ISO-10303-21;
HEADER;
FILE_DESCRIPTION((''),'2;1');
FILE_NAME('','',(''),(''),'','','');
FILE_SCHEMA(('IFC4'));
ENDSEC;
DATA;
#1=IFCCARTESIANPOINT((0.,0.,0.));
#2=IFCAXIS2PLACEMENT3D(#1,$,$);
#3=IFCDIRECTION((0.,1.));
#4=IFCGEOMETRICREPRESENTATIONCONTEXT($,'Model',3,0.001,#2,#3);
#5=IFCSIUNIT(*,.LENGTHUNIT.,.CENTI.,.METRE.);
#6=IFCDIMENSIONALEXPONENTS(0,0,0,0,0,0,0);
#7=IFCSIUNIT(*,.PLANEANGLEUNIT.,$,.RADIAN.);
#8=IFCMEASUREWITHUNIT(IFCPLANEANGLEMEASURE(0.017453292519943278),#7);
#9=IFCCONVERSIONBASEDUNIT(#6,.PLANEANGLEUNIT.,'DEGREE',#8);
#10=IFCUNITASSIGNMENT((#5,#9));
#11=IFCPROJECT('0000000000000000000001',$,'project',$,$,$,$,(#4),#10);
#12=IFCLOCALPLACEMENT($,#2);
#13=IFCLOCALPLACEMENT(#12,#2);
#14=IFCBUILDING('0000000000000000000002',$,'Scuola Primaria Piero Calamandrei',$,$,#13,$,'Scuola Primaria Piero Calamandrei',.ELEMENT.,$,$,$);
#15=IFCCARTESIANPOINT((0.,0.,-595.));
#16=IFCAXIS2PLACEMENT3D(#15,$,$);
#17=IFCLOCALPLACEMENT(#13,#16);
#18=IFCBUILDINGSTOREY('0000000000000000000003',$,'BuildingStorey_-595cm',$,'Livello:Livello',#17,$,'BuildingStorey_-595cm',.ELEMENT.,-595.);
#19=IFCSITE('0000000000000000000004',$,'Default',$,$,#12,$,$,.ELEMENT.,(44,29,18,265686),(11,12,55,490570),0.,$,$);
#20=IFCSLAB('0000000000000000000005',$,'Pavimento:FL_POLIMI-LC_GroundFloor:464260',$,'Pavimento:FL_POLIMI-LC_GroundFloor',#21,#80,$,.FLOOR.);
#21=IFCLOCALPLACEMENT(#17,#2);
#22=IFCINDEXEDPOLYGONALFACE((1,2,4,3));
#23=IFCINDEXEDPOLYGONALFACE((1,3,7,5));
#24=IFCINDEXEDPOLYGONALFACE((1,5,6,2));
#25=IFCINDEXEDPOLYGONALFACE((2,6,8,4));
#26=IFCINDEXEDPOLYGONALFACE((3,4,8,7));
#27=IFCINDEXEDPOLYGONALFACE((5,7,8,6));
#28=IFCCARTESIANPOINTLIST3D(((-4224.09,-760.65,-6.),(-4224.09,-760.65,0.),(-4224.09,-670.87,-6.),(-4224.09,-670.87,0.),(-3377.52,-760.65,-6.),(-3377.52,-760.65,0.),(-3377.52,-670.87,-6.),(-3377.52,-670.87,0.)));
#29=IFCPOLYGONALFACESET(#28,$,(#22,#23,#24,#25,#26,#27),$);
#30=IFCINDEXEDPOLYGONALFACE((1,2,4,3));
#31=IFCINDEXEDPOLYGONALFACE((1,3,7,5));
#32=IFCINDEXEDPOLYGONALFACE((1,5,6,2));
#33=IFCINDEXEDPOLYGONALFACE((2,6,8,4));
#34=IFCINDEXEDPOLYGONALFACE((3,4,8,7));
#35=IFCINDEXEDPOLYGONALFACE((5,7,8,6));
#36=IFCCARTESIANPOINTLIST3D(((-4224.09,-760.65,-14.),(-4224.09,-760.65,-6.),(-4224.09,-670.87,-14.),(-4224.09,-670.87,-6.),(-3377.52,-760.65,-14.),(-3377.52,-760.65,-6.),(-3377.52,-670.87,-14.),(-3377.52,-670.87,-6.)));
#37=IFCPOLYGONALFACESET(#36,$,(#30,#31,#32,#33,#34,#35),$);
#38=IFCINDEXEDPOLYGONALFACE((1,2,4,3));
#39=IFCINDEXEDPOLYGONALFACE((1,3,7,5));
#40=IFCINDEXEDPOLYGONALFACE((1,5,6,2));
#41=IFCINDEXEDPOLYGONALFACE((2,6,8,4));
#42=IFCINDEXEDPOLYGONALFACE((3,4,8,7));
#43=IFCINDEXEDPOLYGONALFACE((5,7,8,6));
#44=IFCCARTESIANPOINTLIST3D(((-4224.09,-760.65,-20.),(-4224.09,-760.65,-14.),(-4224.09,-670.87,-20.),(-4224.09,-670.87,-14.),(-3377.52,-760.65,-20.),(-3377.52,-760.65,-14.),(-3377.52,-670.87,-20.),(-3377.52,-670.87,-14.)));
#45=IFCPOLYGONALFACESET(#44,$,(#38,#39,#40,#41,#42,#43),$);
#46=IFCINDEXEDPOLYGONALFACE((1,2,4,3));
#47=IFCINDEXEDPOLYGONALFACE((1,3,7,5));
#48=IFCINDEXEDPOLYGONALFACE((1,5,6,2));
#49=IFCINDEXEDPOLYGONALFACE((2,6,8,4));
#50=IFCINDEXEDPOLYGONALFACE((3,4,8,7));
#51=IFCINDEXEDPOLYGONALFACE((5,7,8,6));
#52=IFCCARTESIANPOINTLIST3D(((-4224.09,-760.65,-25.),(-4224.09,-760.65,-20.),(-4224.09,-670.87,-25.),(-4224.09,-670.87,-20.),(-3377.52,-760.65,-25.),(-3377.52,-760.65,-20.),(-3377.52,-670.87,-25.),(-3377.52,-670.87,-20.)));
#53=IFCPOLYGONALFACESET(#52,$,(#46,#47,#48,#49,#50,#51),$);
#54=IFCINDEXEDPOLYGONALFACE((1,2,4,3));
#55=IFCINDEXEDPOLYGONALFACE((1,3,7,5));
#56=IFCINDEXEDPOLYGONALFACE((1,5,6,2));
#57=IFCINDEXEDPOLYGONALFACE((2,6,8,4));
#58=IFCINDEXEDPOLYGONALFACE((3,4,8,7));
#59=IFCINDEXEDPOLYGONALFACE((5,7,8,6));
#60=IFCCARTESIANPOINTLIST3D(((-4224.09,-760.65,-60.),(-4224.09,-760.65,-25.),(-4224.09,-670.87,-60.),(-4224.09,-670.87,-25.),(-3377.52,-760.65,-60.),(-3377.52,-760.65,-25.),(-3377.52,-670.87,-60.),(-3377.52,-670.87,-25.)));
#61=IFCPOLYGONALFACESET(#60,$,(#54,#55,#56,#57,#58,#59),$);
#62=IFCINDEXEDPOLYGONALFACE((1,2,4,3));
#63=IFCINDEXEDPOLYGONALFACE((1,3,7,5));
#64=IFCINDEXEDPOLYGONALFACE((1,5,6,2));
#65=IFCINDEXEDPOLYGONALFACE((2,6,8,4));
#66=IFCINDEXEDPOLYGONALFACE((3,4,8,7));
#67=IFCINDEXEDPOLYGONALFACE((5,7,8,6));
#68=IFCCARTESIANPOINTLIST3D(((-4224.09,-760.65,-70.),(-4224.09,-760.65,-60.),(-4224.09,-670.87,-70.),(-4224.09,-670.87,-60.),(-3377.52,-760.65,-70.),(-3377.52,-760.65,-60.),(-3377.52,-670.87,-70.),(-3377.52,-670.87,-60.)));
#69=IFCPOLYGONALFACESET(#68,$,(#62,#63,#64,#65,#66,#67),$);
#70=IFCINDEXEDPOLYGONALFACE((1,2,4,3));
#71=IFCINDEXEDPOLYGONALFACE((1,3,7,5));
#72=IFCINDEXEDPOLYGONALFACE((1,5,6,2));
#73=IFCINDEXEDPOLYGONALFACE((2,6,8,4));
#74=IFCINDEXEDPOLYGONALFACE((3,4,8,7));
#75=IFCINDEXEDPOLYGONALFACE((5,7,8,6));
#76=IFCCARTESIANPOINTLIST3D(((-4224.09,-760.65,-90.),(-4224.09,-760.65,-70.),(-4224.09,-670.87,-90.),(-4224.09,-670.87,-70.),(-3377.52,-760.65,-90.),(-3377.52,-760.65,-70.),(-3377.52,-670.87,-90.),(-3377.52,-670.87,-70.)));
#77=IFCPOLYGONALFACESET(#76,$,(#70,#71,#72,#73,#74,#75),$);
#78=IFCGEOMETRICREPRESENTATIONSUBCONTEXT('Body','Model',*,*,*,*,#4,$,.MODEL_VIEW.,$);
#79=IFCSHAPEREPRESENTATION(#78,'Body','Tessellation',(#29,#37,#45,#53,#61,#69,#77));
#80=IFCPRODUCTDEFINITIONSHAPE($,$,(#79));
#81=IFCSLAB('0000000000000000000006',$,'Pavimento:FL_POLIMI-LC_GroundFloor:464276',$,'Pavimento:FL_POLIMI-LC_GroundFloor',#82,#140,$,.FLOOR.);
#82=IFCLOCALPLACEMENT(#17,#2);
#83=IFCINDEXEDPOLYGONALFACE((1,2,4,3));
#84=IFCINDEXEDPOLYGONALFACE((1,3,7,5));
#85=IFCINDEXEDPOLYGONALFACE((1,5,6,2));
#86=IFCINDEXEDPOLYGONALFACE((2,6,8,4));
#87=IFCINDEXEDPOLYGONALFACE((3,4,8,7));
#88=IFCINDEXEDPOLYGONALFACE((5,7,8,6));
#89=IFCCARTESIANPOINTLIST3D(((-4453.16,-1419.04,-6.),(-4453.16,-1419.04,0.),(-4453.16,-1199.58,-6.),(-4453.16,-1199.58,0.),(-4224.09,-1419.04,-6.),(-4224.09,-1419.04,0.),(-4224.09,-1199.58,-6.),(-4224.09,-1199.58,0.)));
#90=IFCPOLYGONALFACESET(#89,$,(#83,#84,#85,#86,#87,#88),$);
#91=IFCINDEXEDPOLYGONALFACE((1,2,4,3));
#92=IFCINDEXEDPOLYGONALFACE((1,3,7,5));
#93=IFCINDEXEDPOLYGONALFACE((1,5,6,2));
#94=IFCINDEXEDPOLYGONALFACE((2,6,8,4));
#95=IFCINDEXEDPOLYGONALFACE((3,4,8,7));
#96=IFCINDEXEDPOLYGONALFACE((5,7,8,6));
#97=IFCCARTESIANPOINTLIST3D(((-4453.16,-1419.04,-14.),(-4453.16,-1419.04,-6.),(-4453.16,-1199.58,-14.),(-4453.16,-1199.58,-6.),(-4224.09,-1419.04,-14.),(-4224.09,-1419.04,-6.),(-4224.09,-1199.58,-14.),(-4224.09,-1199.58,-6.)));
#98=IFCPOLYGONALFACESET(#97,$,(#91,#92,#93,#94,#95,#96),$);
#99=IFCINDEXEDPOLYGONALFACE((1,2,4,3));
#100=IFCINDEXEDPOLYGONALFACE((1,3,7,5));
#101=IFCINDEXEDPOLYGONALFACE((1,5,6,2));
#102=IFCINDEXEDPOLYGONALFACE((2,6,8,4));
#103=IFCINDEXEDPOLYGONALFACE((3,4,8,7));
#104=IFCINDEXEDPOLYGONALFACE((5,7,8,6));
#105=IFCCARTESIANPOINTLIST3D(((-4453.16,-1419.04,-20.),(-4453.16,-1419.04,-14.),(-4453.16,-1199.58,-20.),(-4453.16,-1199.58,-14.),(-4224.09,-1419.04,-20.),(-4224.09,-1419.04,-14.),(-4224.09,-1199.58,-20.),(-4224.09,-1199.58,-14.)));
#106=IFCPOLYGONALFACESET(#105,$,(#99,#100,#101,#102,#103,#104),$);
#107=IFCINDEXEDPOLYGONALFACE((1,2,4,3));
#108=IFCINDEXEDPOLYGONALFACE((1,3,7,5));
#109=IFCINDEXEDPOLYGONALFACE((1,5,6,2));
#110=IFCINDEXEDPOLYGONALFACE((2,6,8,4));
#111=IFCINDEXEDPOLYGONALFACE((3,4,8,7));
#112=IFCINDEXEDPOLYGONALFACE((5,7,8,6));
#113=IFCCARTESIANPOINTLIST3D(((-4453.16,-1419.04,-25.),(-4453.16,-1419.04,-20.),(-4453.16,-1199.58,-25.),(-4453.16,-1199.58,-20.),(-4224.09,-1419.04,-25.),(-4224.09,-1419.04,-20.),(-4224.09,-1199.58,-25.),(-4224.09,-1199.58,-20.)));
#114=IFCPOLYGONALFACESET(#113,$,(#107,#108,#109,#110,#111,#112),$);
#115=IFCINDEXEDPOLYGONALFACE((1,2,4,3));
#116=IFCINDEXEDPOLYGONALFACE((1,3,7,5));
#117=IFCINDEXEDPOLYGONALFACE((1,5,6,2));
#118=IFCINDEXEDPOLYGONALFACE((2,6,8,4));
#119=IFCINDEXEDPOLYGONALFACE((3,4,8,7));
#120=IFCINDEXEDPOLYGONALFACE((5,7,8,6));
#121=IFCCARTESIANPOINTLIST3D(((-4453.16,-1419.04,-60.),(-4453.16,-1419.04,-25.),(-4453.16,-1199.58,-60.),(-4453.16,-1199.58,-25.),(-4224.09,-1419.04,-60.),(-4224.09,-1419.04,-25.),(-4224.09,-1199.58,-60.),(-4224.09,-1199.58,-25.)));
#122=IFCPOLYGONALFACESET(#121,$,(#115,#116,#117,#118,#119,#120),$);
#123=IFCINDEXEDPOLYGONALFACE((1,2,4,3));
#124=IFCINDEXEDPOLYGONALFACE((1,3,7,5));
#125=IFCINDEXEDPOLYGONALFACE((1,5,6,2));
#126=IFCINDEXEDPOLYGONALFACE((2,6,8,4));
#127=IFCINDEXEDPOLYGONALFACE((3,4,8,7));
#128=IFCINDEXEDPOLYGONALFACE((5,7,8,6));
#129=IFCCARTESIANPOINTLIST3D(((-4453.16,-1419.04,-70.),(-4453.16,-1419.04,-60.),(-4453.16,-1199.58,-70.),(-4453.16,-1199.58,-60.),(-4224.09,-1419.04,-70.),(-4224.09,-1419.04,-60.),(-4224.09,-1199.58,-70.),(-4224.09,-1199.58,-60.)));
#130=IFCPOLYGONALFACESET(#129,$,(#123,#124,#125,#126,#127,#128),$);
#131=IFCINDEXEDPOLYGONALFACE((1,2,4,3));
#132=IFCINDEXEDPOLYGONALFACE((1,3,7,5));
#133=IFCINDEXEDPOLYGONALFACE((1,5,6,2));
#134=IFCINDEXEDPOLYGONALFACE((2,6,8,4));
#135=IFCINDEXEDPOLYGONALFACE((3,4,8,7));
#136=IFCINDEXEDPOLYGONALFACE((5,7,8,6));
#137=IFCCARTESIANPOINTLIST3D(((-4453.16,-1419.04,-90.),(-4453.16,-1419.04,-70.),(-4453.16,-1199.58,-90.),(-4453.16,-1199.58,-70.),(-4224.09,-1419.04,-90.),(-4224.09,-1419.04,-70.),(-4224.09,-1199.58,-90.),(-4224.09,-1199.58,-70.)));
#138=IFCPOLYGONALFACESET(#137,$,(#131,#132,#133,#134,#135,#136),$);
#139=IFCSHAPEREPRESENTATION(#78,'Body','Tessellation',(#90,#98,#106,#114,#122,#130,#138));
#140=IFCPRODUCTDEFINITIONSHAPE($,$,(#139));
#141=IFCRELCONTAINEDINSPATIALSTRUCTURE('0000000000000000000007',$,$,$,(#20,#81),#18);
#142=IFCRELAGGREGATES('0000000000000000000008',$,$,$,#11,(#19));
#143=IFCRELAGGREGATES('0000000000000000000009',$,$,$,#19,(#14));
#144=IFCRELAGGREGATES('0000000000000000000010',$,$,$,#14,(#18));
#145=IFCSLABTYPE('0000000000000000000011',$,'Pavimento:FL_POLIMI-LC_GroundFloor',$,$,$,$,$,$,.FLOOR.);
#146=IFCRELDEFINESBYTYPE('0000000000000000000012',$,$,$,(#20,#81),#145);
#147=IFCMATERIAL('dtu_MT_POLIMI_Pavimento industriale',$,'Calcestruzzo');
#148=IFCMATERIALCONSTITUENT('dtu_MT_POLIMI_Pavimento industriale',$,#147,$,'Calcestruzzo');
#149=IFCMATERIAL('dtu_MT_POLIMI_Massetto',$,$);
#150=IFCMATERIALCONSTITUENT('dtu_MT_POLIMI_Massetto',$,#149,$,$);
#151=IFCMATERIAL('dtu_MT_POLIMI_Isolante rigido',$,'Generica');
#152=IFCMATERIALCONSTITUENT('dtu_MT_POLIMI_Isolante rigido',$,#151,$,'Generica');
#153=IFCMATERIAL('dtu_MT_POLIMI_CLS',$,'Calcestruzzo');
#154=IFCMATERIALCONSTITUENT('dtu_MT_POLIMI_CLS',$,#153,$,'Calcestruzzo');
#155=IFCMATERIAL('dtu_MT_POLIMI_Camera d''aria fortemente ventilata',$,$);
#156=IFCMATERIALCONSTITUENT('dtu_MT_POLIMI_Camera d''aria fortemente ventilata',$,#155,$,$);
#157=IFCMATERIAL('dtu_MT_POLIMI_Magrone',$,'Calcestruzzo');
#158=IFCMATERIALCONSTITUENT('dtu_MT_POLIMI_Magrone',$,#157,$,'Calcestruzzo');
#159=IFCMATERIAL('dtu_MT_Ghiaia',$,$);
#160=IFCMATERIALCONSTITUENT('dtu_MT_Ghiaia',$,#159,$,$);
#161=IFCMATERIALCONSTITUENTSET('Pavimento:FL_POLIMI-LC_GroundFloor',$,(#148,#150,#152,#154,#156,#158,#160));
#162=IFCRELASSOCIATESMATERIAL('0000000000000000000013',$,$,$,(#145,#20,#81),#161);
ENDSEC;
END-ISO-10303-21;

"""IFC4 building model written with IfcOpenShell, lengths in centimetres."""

from ifc_helpers import new_model, entity, si_unit, converted_unit, direction, frame, origin, place, context, subcontext, project, spatial, indexed_curve, outline, extrude, material, constituent, constituent_set, type_object, element, save


model = new_model("IFC4")

# Units and contexts
model_context = context("Model", 3, precision=0.001, world=origin(), true_north=direction((0.0, 1.0)))
body_context = subcontext(model_context, "Body", "Model", "MODEL_VIEW")
ifc_project = project(units=[si_unit("LENGTHUNIT", "METRE", prefix="CENTI"), converted_unit("PLANEANGLEUNIT", "DEGREE", entity("IfcPlaneAngleMeasure", 0.017453292519943278), si_unit("PLANEANGLEUNIT", "RADIAN"), dimensions=[0, 0, 0, 0, 0, 0, 0])], contexts=[model_context])

# Site, building, storey
site_placement = place(None, origin())
site = spatial("IfcSite", under=ifc_project, at=site_placement, Name="Default", CompositionType="ELEMENT", RefLatitude=(44, 29, 18, 265686), RefLongitude=(11, 12, 55, 490570), RefElevation=0.0)
building_placement = place(site_placement, origin())
building = spatial("IfcBuilding", under=site, at=building_placement, Name="Scuola Primaria Piero Calamandrei", LongName="Scuola Primaria Piero Calamandrei", CompositionType="ELEMENT")
storey_placement = place(building_placement, frame((0.0, 0.0, -595.0)))
storey = spatial("IfcBuildingStorey", under=building, at=storey_placement, Name="BuildingStorey_-595cm", ObjectType="Livello:Livello", LongName="BuildingStorey_-595cm", CompositionType="ELEMENT", Elevation=-595.0)

# Slabs
ifc_material_1 = material(Name="dtu_MT_POLIMI_Pavimento industriale", Category="Calcestruzzo")
ifc_constituent_1 = constituent(ifc_material_1, Name="dtu_MT_POLIMI_Pavimento industriale", Category="Calcestruzzo")
ifc_material_2 = material(Name="dtu_MT_POLIMI_Massetto")
ifc_constituent_2 = constituent(ifc_material_2, Name="dtu_MT_POLIMI_Massetto")
ifc_material_3 = material(Name="dtu_MT_POLIMI_Isolante rigido", Category="Generica")
ifc_constituent_3 = constituent(ifc_material_3, Name="dtu_MT_POLIMI_Isolante rigido", Category="Generica")
ifc_material_4 = material(Name="dtu_MT_POLIMI_CLS", Category="Calcestruzzo")
ifc_constituent_4 = constituent(ifc_material_4, Name="dtu_MT_POLIMI_CLS", Category="Calcestruzzo")
ifc_material_5 = material(Name="dtu_MT_POLIMI_Camera d'aria fortemente ventilata")
ifc_constituent_5 = constituent(ifc_material_5, Name="dtu_MT_POLIMI_Camera d'aria fortemente ventilata")
ifc_material_6 = material(Name="dtu_MT_POLIMI_Magrone", Category="Calcestruzzo")
ifc_constituent_6 = constituent(ifc_material_6, Name="dtu_MT_POLIMI_Magrone", Category="Calcestruzzo")
ifc_material_7 = material(Name="dtu_MT_Ghiaia")
ifc_constituent_7 = constituent(ifc_material_7, Name="dtu_MT_Ghiaia")
ifc_constituent_set_1 = constituent_set(constituents=[ifc_constituent_1, ifc_constituent_2, ifc_constituent_3, ifc_constituent_4, ifc_constituent_5, ifc_constituent_6, ifc_constituent_7], Name="Pavimento:FL_POLIMI-LC_GroundFloor")
slab_type = type_object("IfcSlabType", Name="Pavimento:FL_POLIMI-LC_GroundFloor", PredefinedType="FLOOR", material=ifc_constituent_set_1)
slab_1_placement = place(storey_placement, origin())
element("IfcSlab", 1, at=slab_1_placement, inside=storey, type_object=slab_type, material=ifc_constituent_set_1, Name="Pavimento:FL_POLIMI-LC_GroundFloor:464260", ObjectType="Pavimento:FL_POLIMI-LC_GroundFloor", PredefinedType="FLOOR", context=body_context, shape_type="SweptSolid", body=[
    extrude(outline(indexed_curve([(-44.89, -423.28), (44.89, -423.28), (44.89, 423.28), (-44.89, 423.28), (-44.89, -423.28)], self_intersect=False)), frame((-3800.81, -715.76, -6.0), z_axis=(0.0, 0.0, 1.0), x_axis=(0.0, 1.0, 0.0)), (0.0, 0.0, 1.0), 6.0),
    extrude(outline(indexed_curve([(-44.89, -423.28), (44.89, -423.28), (44.89, 423.28), (-44.89, 423.28), (-44.89, -423.28)], self_intersect=False)), frame((-3800.81, -715.76, -14.0), z_axis=(0.0, 0.0, 1.0), x_axis=(0.0, 1.0, 0.0)), (0.0, 0.0, 1.0), 8.0),
    extrude(outline(indexed_curve([(-44.89, -423.28), (44.89, -423.28), (44.89, 423.28), (-44.89, 423.28), (-44.89, -423.28)], self_intersect=False)), frame((-3800.81, -715.76, -20.0), z_axis=(0.0, 0.0, 1.0), x_axis=(0.0, 1.0, 0.0)), (0.0, 0.0, 1.0), 6.0),
    extrude(outline(indexed_curve([(-44.89, -423.28), (44.89, -423.28), (44.89, 423.28), (-44.89, 423.28), (-44.89, -423.28)], self_intersect=False)), frame((-3800.81, -715.76, -25.0), z_axis=(0.0, 0.0, 1.0), x_axis=(0.0, 1.0, 0.0)), (0.0, 0.0, 1.0), 5.0),
    extrude(outline(indexed_curve([(-44.89, -423.28), (44.89, -423.28), (44.89, 423.28), (-44.89, 423.28), (-44.89, -423.28)], self_intersect=False)), frame((-3800.81, -715.76, -60.0), z_axis=(0.0, 0.0, 1.0), x_axis=(0.0, 1.0, 0.0)), (0.0, 0.0, 1.0), 35.0),
    extrude(outline(indexed_curve([(-44.89, -423.28), (44.89, -423.28), (44.89, 423.28), (-44.89, 423.28), (-44.89, -423.28)], self_intersect=False)), frame((-3800.81, -715.76, -70.0), z_axis=(0.0, 0.0, 1.0), x_axis=(0.0, 1.0, 0.0)), (0.0, 0.0, 1.0), 10.0),
    extrude(outline(indexed_curve([(-44.89, -423.28), (44.89, -423.28), (44.89, 423.28), (-44.89, 423.28), (-44.89, -423.28)], self_intersect=False)), frame((-3800.81, -715.76, -90.0), z_axis=(0.0, 0.0, 1.0), x_axis=(0.0, 1.0, 0.0)), (0.0, 0.0, 1.0), 20.0),
])
slab_2_placement = place(storey_placement, origin())
element("IfcSlab", 2, at=slab_2_placement, inside=storey, type_object=slab_type, material=ifc_constituent_set_1, Name="Pavimento:FL_POLIMI-LC_GroundFloor:464276", ObjectType="Pavimento:FL_POLIMI-LC_GroundFloor", PredefinedType="FLOOR", context=body_context, shape_type="SweptSolid", body=[
    extrude(outline(indexed_curve([(-114.54, -109.73), (114.54, -109.73), (114.54, 109.73), (-114.54, 109.73), (-114.54, -109.73)], self_intersect=False)), frame((-4338.63, -1309.31, -6.0)), (0.0, 0.0, 1.0), 6.0),
    extrude(outline(indexed_curve([(-114.54, -109.73), (114.54, -109.73), (114.54, 109.73), (-114.54, 109.73), (-114.54, -109.73)], self_intersect=False)), frame((-4338.63, -1309.31, -14.0)), (0.0, 0.0, 1.0), 8.0),
    extrude(outline(indexed_curve([(-114.54, -109.73), (114.54, -109.73), (114.54, 109.73), (-114.54, 109.73), (-114.54, -109.73)], self_intersect=False)), frame((-4338.63, -1309.31, -20.0)), (0.0, 0.0, 1.0), 6.0),
    extrude(outline(indexed_curve([(-114.54, -109.73), (114.54, -109.73), (114.54, 109.73), (-114.54, 109.73), (-114.54, -109.73)], self_intersect=False)), frame((-4338.63, -1309.31, -25.0)), (0.0, 0.0, 1.0), 5.0),
    extrude(outline(indexed_curve([(-114.54, -109.73), (114.54, -109.73), (114.54, 109.73), (-114.54, 109.73), (-114.54, -109.73)], self_intersect=False)), frame((-4338.63, -1309.31, -60.0)), (0.0, 0.0, 1.0), 35.0),
    extrude(outline(indexed_curve([(-114.54, -109.73), (114.54, -109.73), (114.54, 109.73), (-114.54, 109.73), (-114.54, -109.73)], self_intersect=False)), frame((-4338.63, -1309.31, -70.0)), (0.0, 0.0, 1.0), 10.0),
    extrude(outline(indexed_curve([(-114.54, -109.73), (114.54, -109.73), (114.54, 109.73), (-114.54, 109.73), (-114.54, -109.73)], self_intersect=False)), frame((-4338.63, -1309.31, -90.0)), (0.0, 0.0, 1.0), 20.0),
])

save(model, "model.ifc")
